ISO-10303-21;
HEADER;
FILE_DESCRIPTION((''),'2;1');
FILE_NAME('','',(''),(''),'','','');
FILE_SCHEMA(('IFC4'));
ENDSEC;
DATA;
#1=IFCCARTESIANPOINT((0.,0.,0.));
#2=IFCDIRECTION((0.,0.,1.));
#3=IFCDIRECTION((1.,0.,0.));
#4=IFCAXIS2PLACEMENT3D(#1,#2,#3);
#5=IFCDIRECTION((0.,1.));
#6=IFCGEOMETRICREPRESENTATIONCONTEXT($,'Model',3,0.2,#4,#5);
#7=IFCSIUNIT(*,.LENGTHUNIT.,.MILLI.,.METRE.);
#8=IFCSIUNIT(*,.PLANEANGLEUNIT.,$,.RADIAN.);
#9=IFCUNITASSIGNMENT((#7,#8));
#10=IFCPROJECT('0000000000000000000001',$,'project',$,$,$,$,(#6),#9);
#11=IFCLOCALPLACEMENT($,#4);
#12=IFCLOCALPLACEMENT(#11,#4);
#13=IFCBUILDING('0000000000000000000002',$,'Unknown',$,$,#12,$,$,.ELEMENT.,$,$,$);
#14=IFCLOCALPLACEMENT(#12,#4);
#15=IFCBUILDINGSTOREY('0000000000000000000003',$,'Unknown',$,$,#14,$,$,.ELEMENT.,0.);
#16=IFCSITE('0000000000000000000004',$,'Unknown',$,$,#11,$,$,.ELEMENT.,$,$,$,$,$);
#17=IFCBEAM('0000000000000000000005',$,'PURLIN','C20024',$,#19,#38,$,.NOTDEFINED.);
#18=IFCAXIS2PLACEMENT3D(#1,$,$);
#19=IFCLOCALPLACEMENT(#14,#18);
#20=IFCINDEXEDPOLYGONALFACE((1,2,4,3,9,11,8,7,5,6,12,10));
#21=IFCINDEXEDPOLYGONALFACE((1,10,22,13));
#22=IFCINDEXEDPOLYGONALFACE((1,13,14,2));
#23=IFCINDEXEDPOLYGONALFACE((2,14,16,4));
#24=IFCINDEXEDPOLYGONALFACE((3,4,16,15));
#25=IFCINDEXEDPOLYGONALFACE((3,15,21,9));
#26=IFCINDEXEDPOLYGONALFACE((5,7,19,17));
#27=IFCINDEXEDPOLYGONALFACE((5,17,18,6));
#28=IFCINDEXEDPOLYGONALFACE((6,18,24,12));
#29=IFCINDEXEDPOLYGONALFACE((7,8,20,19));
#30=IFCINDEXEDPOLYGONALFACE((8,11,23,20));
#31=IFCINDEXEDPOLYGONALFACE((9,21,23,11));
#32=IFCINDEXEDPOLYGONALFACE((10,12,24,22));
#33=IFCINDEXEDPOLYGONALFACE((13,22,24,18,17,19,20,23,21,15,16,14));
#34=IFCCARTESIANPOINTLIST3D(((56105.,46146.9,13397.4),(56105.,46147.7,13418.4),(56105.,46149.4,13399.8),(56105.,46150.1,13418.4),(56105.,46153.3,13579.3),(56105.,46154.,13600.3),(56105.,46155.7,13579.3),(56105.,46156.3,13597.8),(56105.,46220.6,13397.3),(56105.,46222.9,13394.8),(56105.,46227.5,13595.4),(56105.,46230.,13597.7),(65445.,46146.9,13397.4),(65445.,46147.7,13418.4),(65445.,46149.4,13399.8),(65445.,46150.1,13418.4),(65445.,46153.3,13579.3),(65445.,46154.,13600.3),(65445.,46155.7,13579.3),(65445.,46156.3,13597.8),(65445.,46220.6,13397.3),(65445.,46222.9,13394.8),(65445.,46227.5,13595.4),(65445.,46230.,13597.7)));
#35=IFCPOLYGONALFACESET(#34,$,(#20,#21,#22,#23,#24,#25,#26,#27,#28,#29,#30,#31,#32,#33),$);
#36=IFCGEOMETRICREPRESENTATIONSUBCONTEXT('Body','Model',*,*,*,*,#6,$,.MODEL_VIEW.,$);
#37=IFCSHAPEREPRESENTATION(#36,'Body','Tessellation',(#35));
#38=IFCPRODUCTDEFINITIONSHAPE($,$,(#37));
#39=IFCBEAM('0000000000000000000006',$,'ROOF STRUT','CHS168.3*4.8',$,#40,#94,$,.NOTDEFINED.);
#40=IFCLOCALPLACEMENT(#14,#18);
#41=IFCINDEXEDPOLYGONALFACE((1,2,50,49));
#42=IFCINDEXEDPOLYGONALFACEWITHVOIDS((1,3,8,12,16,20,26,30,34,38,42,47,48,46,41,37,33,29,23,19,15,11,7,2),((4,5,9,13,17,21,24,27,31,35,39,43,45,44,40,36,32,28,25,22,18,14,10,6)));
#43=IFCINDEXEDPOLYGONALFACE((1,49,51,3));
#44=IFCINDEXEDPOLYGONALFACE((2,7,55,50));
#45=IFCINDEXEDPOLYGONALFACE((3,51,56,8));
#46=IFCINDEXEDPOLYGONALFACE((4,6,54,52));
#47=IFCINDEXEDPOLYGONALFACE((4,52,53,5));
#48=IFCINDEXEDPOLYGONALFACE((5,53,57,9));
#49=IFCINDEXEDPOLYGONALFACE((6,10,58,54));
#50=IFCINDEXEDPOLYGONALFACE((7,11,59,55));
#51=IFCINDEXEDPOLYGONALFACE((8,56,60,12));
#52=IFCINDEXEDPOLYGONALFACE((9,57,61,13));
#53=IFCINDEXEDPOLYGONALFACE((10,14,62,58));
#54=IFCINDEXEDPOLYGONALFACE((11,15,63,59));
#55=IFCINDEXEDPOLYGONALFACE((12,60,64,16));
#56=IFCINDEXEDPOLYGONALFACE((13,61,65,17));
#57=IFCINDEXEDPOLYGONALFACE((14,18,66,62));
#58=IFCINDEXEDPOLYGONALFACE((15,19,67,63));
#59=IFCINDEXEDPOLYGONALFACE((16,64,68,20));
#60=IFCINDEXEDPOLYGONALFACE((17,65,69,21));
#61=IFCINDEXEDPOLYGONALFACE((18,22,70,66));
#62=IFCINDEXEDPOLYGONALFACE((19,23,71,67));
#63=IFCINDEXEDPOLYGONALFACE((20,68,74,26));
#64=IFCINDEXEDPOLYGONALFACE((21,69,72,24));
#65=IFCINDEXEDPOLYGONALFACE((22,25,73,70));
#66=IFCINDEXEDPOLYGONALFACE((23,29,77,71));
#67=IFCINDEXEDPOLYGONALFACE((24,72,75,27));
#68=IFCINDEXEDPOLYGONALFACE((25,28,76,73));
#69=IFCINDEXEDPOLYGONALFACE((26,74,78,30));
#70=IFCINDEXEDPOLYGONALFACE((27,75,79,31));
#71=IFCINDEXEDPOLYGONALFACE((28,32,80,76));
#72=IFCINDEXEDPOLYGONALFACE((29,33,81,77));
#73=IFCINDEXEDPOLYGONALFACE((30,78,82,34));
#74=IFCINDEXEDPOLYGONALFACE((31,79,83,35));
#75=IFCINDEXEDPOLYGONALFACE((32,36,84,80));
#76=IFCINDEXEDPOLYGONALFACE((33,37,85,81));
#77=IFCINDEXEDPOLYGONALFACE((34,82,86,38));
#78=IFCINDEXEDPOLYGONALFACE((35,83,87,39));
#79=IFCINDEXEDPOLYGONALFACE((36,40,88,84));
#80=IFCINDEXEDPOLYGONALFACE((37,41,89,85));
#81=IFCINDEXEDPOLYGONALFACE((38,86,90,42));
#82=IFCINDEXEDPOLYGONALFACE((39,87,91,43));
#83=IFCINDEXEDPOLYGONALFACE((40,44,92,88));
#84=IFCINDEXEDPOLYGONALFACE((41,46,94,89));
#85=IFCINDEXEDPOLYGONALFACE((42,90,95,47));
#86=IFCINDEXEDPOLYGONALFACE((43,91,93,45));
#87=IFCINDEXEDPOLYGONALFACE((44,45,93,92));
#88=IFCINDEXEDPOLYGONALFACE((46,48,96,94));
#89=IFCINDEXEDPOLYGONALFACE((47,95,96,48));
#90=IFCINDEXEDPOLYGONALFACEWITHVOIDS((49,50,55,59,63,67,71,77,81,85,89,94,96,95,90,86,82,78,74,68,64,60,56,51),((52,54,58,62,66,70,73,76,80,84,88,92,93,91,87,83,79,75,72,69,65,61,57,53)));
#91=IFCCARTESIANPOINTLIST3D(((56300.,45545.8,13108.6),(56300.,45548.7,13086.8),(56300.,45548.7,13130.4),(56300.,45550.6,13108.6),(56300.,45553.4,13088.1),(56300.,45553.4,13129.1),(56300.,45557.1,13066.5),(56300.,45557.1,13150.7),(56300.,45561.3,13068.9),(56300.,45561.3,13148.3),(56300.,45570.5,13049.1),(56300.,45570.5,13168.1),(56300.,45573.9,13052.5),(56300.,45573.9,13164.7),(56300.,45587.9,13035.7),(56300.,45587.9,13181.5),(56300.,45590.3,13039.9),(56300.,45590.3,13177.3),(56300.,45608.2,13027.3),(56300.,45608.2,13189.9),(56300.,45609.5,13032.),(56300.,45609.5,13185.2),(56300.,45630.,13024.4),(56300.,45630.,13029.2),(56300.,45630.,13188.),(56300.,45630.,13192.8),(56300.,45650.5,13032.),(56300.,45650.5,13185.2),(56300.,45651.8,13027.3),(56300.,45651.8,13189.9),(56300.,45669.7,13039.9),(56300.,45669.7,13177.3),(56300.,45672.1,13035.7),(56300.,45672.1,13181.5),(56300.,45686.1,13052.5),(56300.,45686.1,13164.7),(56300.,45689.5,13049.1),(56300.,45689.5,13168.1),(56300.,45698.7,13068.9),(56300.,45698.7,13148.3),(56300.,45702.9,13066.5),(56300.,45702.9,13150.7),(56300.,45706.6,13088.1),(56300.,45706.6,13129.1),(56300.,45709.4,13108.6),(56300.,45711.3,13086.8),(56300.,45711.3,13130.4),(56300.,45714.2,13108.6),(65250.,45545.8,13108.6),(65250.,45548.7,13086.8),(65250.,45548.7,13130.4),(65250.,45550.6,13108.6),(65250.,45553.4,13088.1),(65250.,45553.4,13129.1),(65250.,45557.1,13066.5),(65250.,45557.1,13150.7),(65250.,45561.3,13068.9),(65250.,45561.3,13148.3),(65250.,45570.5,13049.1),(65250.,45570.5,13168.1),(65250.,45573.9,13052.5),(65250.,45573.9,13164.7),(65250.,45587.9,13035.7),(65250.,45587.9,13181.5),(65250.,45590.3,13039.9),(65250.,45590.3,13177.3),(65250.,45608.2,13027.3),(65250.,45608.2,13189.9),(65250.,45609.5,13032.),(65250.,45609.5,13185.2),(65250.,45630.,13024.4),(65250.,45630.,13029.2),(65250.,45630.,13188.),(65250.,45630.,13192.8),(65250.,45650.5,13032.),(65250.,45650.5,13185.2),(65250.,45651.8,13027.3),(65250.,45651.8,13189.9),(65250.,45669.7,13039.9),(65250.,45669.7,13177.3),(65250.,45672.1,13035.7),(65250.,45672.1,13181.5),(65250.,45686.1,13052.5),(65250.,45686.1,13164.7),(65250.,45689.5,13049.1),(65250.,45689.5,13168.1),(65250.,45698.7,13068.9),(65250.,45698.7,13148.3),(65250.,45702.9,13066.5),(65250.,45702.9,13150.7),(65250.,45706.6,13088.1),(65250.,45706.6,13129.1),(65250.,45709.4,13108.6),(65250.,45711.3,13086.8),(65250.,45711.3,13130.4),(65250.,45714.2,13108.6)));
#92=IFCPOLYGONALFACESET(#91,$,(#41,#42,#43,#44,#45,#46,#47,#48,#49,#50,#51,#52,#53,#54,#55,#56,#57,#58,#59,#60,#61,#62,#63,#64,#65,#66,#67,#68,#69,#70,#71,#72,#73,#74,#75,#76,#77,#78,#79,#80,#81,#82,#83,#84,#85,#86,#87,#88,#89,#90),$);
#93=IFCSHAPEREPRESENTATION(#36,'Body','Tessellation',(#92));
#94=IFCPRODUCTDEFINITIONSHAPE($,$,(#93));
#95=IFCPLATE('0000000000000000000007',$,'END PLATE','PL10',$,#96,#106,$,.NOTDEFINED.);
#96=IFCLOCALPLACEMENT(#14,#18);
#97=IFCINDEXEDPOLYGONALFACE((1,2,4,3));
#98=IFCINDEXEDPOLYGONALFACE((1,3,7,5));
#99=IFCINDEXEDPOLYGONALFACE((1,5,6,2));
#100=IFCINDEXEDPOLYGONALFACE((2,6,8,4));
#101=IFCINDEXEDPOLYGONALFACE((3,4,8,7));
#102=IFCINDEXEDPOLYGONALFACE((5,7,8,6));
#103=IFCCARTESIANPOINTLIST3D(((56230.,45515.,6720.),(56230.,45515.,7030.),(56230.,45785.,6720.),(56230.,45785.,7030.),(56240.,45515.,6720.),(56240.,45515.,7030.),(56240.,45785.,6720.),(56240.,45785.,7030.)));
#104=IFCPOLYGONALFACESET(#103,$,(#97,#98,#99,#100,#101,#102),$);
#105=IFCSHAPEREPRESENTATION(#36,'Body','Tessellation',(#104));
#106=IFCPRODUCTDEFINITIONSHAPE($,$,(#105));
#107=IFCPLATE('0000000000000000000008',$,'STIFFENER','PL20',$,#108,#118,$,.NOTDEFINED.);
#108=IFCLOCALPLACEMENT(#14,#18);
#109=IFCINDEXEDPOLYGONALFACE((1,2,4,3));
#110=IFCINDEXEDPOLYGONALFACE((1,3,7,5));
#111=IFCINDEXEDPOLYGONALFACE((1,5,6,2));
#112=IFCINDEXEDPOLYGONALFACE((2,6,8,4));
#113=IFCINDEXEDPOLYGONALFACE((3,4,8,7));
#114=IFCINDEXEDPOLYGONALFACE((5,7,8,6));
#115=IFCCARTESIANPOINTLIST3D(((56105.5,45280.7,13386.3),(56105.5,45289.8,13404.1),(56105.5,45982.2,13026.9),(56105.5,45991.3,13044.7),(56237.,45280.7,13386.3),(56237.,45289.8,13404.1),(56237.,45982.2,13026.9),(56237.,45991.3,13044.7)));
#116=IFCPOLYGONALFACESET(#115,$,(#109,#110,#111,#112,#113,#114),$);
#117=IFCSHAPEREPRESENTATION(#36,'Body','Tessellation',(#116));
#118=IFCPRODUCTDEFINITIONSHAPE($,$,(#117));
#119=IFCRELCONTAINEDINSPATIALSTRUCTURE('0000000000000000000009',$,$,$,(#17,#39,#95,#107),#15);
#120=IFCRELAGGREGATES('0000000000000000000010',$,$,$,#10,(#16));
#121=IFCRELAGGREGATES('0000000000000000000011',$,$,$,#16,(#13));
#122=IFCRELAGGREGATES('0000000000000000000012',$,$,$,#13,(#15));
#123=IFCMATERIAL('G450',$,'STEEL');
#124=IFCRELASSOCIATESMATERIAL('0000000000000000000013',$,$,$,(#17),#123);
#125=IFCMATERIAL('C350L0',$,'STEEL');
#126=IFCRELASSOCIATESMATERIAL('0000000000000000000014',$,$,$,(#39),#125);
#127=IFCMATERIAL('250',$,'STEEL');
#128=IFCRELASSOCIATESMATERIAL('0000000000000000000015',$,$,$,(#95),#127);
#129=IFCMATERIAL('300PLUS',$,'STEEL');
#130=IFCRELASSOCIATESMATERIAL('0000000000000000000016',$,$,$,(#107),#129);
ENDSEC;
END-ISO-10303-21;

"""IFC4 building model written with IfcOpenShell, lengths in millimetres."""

from ifc_helpers import new_model, si_unit, direction, frame, origin_with_axes, place, context, subcontext, project, spatial, line, indexed_curve, outline, extrude, material, element, save


model = new_model("IFC4")

# Units and contexts
model_context = context("Model", 3, precision=0.2, world=origin_with_axes(), true_north=direction((0.0, 1.0)))
body_context = subcontext(model_context, "Body", "Model", "MODEL_VIEW")
ifc_project = project(units=[si_unit("LENGTHUNIT", "METRE", prefix="MILLI"), si_unit("PLANEANGLEUNIT", "RADIAN")], contexts=[model_context])

# Site, building, storey
site_placement = place(None, origin_with_axes())
site = spatial("IfcSite", under=ifc_project, at=site_placement, Name="Unknown", CompositionType="ELEMENT")
building_placement = place(site_placement, origin_with_axes())
building = spatial("IfcBuilding", under=site, at=building_placement, Name="Unknown", CompositionType="ELEMENT")
storey_placement = place(building_placement, origin_with_axes())
storey = spatial("IfcBuildingStorey", under=building, at=storey_placement, Name="Unknown", CompositionType="ELEMENT", Elevation=0.0)

# Shared definitions
ifc_material_1 = material(Name="G450", Category="STEEL")

# Beams
ifc_material_2 = material(Name="C350L0", Category="STEEL")
ifc_material_3 = material(Name="300PLUS", Category="STEEL")
beam_1_placement = place(storey_placement, frame((56105.0, 46188.5, 13497.6), z_axis=(0.0, -0.999391, 0.034899), x_axis=(1.0, 0.0, 0.0)))
element("IfcBeam", 1, at=beam_1_placement, inside=storey, material=ifc_material_1, Name="PURLIN", Description="C20024", PredefinedType="NOTDEFINED", context=body_context, shape_type="SolidModel", body=[
    extrude(outline(indexed_curve([(38.0, -101.5), (38.0, -80.5), (35.6, -80.5), (35.6, -99.1), (-35.6, -99.1), (-35.6, 99.1), (35.6, 99.1), (35.6, 80.5), (38.0, 80.5), (38.0, 101.5), (-38.0, 101.5), (-38.0, -101.5)], segments=[line(1, 2, 3, 4, 5, 6, 7, 8, 9, 10, 11, 12, 1)])), frame((0.0, 0.0, 0.0), z_axis=(-1.0, 0.0, 0.0), x_axis=(0.0, 0.0, 1.0)), (0.0, 0.0, -1.0), 9340.0),
])
beam_2_placement = place(storey_placement, frame((56300.0, 45630.0, 13108.6), z_axis=(0.0, 0.0, 1.0), x_axis=(1.0, 0.0, 0.0)))
element("IfcBeam", 2, at=beam_2_placement, inside=storey, material=ifc_material_2, Name="ROOF STRUT", Description="CHS168.3*4.8", PredefinedType="NOTDEFINED", context=body_context, shape_type="SolidModel", body=[
    extrude(outline(indexed_curve([(84.2, 0.0), (81.3, 21.8), (72.9, 42.1), (59.5, 59.5), (42.1, 72.9), (21.8, 81.3), (0.0, 84.2), (-21.8, 81.3), (-42.1, 72.9), (-59.5, 59.5), (-72.9, 42.1), (-81.3, 21.8), (-84.2, 0.0), (-81.3, -21.8), (-72.9, -42.1), (-59.5, -59.5), (-42.1, -72.9), (-21.8, -81.3), (0.0, -84.2), (21.8, -81.3), (42.1, -72.9), (59.5, -59.5), (72.9, -42.1), (81.3, -21.8)], segments=[line(1, 2, 3, 4, 5, 6, 7, 8, 9, 10, 11, 12, 13, 14, 15, 16, 17, 18, 19, 20, 21, 22, 23, 24, 1)]), holes=[indexed_curve([(79.3, 0.0), (76.6, -20.5), (68.7, -39.7), (56.1, -56.1), (39.7, -68.7), (20.5, -76.6), (0.0, -79.3), (-20.5, -76.6), (-39.7, -68.7), (-56.1, -56.1), (-68.7, -39.7), (-76.6, -20.5), (-79.3, 0.0), (-76.6, 20.5), (-68.7, 39.7), (-56.1, 56.1), (-39.7, 68.7), (-20.5, 76.6), (0.0, 79.3), (20.5, 76.6), (39.7, 68.7), (56.1, 56.1), (68.7, 39.7), (76.6, 20.5)], segments=[line(1, 2, 3, 4, 5, 6, 7, 8, 9, 10, 11, 12, 13, 14, 15, 16, 17, 18, 19, 20, 21, 22, 23, 24, 1)])]), frame((0.0, 0.0, 0.0), z_axis=(-1.0, 0.0, 0.0), x_axis=(0.0, 0.0, 1.0)), (0.0, 0.0, -1.0), 8950.0),
])

# Plates
ifc_material_4 = material(Name="250", Category="STEEL")
plate_1_placement = place(storey_placement, frame((56235.0, 45785.0, 6720.0), z_axis=(-1.0, 0.0, 0.0), x_axis=(0.0, -1.0, 0.0)))
element("IfcPlate", 3, at=plate_1_placement, inside=storey, material=ifc_material_4, Name="END PLATE", Description="PL10", PredefinedType="NOTDEFINED", context=body_context, shape_type="SolidModel", body=[
    extrude(outline(indexed_curve([(0.0, 0.0), (270.0, 0.0), (270.0, 310.0), (0.0, 310.0)], segments=[line(1, 2, 3, 4, 1)])), frame((0.0, 0.0, 5.0), z_axis=(0.0, 0.0, 1.0), x_axis=(1.0, 0.0, 0.0)), (0.0, 0.0, -1.0), 10.0),
])
plate_2_placement = place(storey_placement, frame((56105.5, 45986.8, 13035.8), z_axis=(0.0, 0.455971, 0.889994), x_axis=(0.0, -0.889994, 0.455971)))
element("IfcPlate", 4, at=plate_2_placement, inside=storey, material=ifc_material_3, Name="STIFFENER", Description="PL20", PredefinedType="NOTDEFINED", context=body_context, shape_type="SolidModel", body=[
    extrude(outline(indexed_curve([(0.0, 0.0), (788.2, 0.0), (788.2, 131.5), (0.0, 131.5)], segments=[line(1, 2, 3, 4, 1)])), frame((0.0, 0.0, 10.0), z_axis=(0.0, 0.0, 1.0), x_axis=(1.0, 0.0, 0.0)), (0.0, 0.0, -1.0), 20.0),
])

save(model, "model.ifc")
